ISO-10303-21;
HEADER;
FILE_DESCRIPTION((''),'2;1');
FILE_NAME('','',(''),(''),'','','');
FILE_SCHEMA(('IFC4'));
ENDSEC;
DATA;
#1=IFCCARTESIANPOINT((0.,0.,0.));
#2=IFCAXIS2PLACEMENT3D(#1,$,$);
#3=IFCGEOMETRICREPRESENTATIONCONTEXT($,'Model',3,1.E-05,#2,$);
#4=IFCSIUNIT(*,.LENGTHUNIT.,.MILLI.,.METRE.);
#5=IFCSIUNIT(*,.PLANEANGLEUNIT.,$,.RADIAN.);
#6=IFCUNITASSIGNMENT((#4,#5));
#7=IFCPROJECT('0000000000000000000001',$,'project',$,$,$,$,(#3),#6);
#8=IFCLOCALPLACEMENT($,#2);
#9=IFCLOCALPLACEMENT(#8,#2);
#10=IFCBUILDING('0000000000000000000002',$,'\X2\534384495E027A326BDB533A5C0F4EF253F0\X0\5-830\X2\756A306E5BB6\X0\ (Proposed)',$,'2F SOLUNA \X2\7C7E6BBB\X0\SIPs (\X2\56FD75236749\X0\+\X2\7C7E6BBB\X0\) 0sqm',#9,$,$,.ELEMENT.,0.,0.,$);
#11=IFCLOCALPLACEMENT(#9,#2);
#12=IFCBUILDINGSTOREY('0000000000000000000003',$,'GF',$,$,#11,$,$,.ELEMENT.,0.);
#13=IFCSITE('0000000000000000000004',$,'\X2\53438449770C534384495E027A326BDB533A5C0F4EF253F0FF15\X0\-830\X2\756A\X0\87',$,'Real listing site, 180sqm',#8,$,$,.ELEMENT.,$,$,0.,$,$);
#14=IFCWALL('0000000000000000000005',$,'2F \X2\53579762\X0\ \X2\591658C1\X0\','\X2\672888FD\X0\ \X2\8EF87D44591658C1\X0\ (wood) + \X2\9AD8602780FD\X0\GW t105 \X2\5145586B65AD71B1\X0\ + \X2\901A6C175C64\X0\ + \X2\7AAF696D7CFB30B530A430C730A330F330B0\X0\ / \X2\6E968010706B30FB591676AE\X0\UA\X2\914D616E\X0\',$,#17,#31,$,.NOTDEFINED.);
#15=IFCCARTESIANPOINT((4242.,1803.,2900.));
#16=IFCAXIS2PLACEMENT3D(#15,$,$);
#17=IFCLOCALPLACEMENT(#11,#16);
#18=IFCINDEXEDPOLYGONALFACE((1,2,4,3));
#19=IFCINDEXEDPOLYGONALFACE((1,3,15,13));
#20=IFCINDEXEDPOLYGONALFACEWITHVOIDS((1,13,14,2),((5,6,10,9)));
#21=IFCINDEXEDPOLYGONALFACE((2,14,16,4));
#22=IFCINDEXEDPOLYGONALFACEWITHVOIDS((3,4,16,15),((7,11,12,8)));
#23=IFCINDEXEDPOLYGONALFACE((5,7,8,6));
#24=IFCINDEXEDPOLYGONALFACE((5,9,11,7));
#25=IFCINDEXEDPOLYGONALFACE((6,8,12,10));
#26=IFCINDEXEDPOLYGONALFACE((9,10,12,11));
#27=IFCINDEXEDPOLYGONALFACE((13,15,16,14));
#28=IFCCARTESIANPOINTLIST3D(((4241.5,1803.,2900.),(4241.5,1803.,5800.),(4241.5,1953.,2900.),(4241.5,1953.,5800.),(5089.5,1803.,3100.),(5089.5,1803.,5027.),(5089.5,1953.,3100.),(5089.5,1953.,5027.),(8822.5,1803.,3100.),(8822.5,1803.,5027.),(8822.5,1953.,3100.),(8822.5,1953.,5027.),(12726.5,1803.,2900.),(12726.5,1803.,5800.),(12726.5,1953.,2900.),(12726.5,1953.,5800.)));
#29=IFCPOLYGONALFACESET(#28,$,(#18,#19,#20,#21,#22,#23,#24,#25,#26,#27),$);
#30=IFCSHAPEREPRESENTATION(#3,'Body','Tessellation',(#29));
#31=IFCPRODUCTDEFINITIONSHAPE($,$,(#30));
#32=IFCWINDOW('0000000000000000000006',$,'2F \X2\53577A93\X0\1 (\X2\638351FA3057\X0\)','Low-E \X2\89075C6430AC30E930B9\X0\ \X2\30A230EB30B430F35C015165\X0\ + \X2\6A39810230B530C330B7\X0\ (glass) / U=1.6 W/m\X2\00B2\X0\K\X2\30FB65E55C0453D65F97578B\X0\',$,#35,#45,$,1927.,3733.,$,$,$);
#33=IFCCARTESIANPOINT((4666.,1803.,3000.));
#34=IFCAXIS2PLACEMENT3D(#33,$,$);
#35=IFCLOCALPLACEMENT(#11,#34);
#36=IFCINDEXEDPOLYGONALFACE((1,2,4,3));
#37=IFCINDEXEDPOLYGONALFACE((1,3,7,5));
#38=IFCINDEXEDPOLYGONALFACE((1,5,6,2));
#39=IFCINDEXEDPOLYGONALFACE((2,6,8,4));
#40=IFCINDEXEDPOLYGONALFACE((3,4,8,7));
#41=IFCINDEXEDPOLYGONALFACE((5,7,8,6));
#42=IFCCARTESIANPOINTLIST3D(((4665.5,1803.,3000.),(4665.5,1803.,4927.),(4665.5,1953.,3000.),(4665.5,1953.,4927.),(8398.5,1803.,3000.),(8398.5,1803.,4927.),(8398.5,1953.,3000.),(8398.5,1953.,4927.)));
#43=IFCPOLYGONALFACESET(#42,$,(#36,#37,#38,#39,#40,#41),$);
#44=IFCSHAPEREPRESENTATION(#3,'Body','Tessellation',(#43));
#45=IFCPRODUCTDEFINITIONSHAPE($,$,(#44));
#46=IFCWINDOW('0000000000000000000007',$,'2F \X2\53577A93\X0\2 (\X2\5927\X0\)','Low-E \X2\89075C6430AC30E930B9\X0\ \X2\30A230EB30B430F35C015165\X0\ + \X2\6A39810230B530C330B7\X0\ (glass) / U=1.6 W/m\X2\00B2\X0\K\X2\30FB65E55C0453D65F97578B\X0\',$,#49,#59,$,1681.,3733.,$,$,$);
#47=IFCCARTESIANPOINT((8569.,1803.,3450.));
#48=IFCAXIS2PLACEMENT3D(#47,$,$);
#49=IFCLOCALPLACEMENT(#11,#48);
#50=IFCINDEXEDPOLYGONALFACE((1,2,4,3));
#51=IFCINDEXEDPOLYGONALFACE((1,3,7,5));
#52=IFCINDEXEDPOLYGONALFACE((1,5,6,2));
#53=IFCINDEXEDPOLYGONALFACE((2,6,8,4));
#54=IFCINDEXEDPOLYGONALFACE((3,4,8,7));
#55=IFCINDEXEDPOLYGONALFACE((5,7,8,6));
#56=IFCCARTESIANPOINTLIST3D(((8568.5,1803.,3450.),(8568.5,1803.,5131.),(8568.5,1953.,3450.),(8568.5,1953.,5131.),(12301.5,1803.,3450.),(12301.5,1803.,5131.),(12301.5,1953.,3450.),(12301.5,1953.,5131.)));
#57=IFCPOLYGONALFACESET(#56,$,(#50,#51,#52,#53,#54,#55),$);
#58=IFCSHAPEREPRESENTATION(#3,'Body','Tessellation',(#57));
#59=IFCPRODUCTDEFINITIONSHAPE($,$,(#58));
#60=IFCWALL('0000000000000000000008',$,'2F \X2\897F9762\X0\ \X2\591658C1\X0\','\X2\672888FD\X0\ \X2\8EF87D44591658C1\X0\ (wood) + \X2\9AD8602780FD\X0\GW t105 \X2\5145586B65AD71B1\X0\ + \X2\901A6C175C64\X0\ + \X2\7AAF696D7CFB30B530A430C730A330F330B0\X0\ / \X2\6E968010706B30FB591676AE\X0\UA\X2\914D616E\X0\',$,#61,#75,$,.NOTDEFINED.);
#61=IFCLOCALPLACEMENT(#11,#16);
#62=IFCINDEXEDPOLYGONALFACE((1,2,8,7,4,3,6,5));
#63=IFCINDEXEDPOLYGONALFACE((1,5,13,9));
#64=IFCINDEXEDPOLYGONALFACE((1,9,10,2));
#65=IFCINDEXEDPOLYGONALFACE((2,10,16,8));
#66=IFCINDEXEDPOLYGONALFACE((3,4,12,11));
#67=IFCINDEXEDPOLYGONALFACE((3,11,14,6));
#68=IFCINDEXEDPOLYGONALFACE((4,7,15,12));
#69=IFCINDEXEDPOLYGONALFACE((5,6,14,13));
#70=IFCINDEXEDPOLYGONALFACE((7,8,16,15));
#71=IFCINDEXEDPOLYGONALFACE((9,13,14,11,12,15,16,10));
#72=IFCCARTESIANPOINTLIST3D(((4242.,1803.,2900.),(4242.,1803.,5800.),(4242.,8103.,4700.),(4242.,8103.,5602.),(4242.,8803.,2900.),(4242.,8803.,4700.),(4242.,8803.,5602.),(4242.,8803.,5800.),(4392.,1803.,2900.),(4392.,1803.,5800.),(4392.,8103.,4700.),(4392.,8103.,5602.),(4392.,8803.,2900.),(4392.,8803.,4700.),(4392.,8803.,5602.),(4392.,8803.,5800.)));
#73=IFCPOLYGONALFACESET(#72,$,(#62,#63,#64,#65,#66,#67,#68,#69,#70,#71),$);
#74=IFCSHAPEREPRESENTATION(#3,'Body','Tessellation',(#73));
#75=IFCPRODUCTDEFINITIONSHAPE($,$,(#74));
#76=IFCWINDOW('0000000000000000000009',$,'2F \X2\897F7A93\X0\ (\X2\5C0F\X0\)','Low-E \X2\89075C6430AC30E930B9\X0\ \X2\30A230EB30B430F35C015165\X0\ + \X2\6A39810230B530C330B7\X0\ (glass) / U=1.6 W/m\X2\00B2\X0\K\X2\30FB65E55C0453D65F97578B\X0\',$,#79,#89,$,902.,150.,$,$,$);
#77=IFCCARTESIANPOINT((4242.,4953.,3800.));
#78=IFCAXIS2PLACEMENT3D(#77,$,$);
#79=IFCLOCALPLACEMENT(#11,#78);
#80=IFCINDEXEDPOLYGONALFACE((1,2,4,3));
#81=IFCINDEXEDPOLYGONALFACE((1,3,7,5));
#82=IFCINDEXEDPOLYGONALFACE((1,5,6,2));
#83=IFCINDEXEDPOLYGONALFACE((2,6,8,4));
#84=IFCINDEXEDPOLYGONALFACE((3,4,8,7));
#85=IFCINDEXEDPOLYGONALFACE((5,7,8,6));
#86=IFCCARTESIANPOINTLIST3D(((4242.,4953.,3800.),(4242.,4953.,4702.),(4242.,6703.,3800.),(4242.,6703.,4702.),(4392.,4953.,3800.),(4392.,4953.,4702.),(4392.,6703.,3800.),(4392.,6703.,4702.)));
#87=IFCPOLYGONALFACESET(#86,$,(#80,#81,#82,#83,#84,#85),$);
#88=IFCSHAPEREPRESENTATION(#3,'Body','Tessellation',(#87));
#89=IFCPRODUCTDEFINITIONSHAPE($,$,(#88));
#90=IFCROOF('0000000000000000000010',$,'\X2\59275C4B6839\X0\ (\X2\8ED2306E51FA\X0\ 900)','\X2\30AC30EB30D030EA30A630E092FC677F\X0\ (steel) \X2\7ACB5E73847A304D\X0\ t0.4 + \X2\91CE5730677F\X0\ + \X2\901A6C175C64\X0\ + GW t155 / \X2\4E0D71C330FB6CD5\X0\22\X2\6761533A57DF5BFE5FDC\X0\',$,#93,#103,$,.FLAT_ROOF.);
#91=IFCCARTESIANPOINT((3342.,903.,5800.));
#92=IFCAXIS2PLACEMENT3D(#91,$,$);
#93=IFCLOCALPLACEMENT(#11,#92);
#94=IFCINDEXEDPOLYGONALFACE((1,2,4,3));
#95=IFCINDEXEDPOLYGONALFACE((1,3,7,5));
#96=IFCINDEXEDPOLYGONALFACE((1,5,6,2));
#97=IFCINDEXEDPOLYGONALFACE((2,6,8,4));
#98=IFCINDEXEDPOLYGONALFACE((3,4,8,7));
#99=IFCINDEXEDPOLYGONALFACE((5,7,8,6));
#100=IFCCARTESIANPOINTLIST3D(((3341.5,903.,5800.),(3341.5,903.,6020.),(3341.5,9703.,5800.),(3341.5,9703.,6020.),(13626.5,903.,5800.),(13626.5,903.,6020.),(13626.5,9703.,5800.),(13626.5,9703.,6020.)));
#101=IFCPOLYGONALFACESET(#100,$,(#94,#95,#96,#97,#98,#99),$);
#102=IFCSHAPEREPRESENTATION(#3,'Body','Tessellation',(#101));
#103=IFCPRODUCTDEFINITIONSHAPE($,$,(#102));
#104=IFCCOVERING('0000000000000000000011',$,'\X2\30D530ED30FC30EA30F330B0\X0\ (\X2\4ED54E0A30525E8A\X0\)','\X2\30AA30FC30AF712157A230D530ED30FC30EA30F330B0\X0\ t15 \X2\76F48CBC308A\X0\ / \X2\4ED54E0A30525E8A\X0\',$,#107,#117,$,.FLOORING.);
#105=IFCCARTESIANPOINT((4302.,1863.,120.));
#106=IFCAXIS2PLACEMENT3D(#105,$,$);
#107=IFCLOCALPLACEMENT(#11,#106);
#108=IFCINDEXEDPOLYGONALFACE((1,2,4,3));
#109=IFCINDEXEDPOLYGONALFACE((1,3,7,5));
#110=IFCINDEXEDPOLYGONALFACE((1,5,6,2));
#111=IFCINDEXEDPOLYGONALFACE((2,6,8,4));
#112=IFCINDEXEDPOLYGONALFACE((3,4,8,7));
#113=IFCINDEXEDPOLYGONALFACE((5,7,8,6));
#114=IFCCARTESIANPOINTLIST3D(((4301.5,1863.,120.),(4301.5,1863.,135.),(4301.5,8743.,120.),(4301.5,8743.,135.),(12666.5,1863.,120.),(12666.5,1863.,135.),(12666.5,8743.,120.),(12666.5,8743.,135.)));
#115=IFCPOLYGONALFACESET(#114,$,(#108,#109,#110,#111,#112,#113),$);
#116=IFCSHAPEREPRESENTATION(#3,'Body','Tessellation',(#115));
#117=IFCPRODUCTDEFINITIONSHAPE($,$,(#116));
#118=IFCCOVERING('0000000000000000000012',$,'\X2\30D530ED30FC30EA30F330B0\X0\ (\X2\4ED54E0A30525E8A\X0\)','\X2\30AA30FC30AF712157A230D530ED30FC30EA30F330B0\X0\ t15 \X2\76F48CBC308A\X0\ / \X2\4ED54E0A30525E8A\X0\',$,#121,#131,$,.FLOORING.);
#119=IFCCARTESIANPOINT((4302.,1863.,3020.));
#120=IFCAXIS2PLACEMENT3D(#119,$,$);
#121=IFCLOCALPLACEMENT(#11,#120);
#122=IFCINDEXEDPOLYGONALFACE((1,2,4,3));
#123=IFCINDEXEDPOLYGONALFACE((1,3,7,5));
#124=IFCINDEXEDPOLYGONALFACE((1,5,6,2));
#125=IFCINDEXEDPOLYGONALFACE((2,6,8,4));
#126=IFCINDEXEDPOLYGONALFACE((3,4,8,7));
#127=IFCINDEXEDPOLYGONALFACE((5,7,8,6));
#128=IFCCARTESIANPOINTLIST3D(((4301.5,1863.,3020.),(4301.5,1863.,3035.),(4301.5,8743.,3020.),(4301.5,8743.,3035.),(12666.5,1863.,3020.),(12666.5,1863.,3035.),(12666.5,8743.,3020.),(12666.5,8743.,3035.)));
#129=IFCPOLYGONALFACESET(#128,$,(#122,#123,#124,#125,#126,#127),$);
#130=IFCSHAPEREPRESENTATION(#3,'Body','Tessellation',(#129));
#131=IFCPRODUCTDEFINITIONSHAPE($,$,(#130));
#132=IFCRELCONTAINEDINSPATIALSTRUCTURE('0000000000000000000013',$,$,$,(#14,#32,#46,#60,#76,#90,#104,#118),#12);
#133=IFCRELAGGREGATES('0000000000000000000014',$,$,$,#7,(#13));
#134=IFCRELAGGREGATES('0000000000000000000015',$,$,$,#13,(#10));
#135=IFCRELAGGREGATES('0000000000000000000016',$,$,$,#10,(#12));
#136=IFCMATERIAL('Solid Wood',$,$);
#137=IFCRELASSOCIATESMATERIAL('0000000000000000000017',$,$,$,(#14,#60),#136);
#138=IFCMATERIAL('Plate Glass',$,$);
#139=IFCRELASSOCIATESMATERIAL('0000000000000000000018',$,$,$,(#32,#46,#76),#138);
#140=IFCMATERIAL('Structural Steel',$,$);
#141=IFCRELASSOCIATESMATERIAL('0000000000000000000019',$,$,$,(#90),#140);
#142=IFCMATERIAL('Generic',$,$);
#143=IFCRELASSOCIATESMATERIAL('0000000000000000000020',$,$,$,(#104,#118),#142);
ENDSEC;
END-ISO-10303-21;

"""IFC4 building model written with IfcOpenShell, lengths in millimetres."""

from ifc_helpers import new_model, si_unit, frame, frame_2d, origin, place, context, project, spatial, rectangle, extrude, material, element, fill, save


model = new_model("IFC4")

# Units and contexts
model_context = context("Model", 3, precision=1e-05, world=origin())
ifc_project = project(units=[si_unit("LENGTHUNIT", "METRE", prefix="MILLI"), si_unit("PLANEANGLEUNIT", "RADIAN")], contexts=[model_context])

# Site, building, storey
site_placement = place(None, origin())
site = spatial("IfcSite", under=ifc_project, at=site_placement, Name="千葉県千葉市稲毛区小仲台５-830番87", ObjectType="Real listing site, 180sqm", CompositionType="ELEMENT", RefElevation=0.0)
building_placement = place(site_placement, origin())
building = spatial("IfcBuilding", under=site, at=building_placement, Name="千葉市稲毛区小仲台5-830番の家 (Proposed)", ObjectType="2F SOLUNA 籾殻SIPs (国産杉+籾殻) 0sqm", CompositionType="ELEMENT", ElevationOfRefHeight=0.0, ElevationOfTerrain=0.0)
storey_placement = place(building_placement, origin())
storey = spatial("IfcBuildingStorey", under=building, at=storey_placement, Name="GF", CompositionType="ELEMENT", Elevation=0.0)

# Shared definitions
ifc_material_1 = material(Name="Solid Wood")

# Shared definitions
ifc_material_2 = material(Name="Plate Glass")

# Wall, openings, windows
wall_1_placement = place(storey_placement, frame((4242.0, 1803.0, 2900.0)))
wall_1 = element("IfcWall", 1, at=wall_1_placement, inside=storey, material=ifc_material_1, Name="2F 南面 外壁", Description="木製 軸組外壁 (wood) + 高性能GW t105 充填断熱 + 通気層 + 窯業系サイディング / 準耐火・外皮UA配慮", PredefinedType="NOTDEFINED", context=model_context, shape_type="SweptSolid", body=[
    extrude(rectangle(XDim=8485.0, YDim=150.0, at=frame_2d((4242.0, 75.0))), frame((4242.0, 1803.0, 2900.0)), (0.0, 0.0, 1.0), 2900.0),
])
opening_1_placement = place(storey_placement, frame((4666.0, 1803.0, 3000.0)))
opening_1 = element("IfcOpeningElement", 2, at=opening_1_placement, cuts=wall_1, PredefinedType="NOTDEFINED", context=model_context, shape_type="SweptSolid", body=[
    extrude(rectangle(XDim=3733.0, YDim=150.0, at=frame_2d((1866.0, 75.0))), frame((4666.0, 1803.0, 3000.0)), (0.0, 0.0, 1.0), 1927.0),
])
opening_2_placement = place(storey_placement, frame((8569.0, 1803.0, 3450.0)))
opening_2 = element("IfcOpeningElement", 3, at=opening_2_placement, cuts=wall_1, PredefinedType="NOTDEFINED", context=model_context, shape_type="SweptSolid", body=[
    extrude(rectangle(XDim=3733.0, YDim=150.0, at=frame_2d((1866.0, 75.0))), frame((8569.0, 1803.0, 3450.0)), (0.0, 0.0, 1.0), 1681.0),
])
window_1_placement = place(storey_placement, frame((4666.0, 1803.0, 3000.0)))
window_1 = element("IfcWindow", 4, at=window_1_placement, inside=storey, material=ifc_material_2, Name="2F 南窓1 (掃出し)", Description="Low-E 複層ガラス アルゴン封入 + 樹脂サッシ (glass) / U=1.6 W/m²K・日射取得型", OverallHeight=1927.0, OverallWidth=3733.0, context=model_context, shape_type="SweptSolid", body=[
    extrude(rectangle(XDim=3733.0, YDim=150.0, at=frame_2d((1866.0, 75.0))), frame((4666.0, 1803.0, 3000.0)), (0.0, 0.0, 1.0), 1927.0),
])
fill(opening_1, window_1)
window_2_placement = place(storey_placement, frame((8569.0, 1803.0, 3450.0)))
window_2 = element("IfcWindow", 5, at=window_2_placement, inside=storey, material=ifc_material_2, Name="2F 南窓2 (大)", Description="Low-E 複層ガラス アルゴン封入 + 樹脂サッシ (glass) / U=1.6 W/m²K・日射取得型", OverallHeight=1681.0, OverallWidth=3733.0, context=model_context, shape_type="SweptSolid", body=[
    extrude(rectangle(XDim=3733.0, YDim=150.0, at=frame_2d((1866.0, 75.0))), frame((8569.0, 1803.0, 3450.0)), (0.0, 0.0, 1.0), 1681.0),
])
fill(opening_2, window_2)

# Wall, opening, window
wall_2_placement = place(storey_placement, frame((4242.0, 1803.0, 2900.0)))
wall_2 = element("IfcWall", 6, at=wall_2_placement, inside=storey, material=ifc_material_1, Name="2F 西面 外壁", Description="木製 軸組外壁 (wood) + 高性能GW t105 充填断熱 + 通気層 + 窯業系サイディング / 準耐火・外皮UA配慮", PredefinedType="NOTDEFINED", context=model_context, shape_type="SweptSolid", body=[
    extrude(rectangle(XDim=150.0, YDim=7000.0, at=frame_2d((75.0, 3500.0))), frame((4242.0, 1803.0, 2900.0)), (0.0, 0.0, 1.0), 2900.0),
])
opening_3_placement = place(storey_placement, frame((4242.0, 4953.0, 3800.0)))
opening_3 = element("IfcOpeningElement", 7, at=opening_3_placement, cuts=wall_2, PredefinedType="NOTDEFINED", context=model_context, shape_type="SweptSolid", body=[
    extrude(rectangle(XDim=150.0, YDim=1750.0, at=frame_2d((75.0, 875.0))), frame((4242.0, 4953.0, 3800.0)), (0.0, 0.0, 1.0), 902.0),
])
window_3_placement = place(storey_placement, frame((4242.0, 4953.0, 3800.0)))
window_3 = element("IfcWindow", 8, at=window_3_placement, inside=storey, material=ifc_material_2, Name="2F 西窓 (小)", Description="Low-E 複層ガラス アルゴン封入 + 樹脂サッシ (glass) / U=1.6 W/m²K・日射取得型", OverallHeight=902.0, OverallWidth=150.0, context=model_context, shape_type="SweptSolid", body=[
    extrude(rectangle(XDim=150.0, YDim=1750.0, at=frame_2d((75.0, 875.0))), frame((4242.0, 4953.0, 3800.0)), (0.0, 0.0, 1.0), 902.0),
])
fill(opening_3, window_3)

# Roof
ifc_material_3 = material(Name="Structural Steel")
roof_placement = place(storey_placement, frame((3342.0, 903.0, 5800.0)))
element("IfcRoof", 9, at=roof_placement, inside=storey, material=ifc_material_3, Name="大屋根 (軒の出 900)", Description="ガルバリウム鋼板 (steel) 立平葺き t0.4 + 野地板 + 通気層 + GW t155 / 不燃・法22条区域対応", PredefinedType="FLAT_ROOF", context=model_context, shape_type="SweptSolid", body=[
    extrude(rectangle(XDim=10285.0, YDim=8800.0, at=frame_2d((5142.0, 4400.0))), frame((3342.0, 903.0, 5800.0)), (0.0, 0.0, 1.0), 220.0),
])

# Coverings
ifc_material_4 = material(Name="Generic")
covering_1_placement = place(storey_placement, frame((4302.0, 1863.0, 120.0)))
element("IfcCovering", 10, at=covering_1_placement, inside=storey, material=ifc_material_4, Name="フローリング (仕上げ床)", Description="オーク無垢フローリング t15 直貼り / 仕上げ床", PredefinedType="FLOORING", context=model_context, shape_type="SweptSolid", body=[
    extrude(rectangle(XDim=8365.0, YDim=6880.0, at=frame_2d((4182.0, 3440.0))), frame((4302.0, 1863.0, 120.0)), (0.0, 0.0, 1.0), 15.0),
])
covering_2_placement = place(storey_placement, frame((4302.0, 1863.0, 3020.0)))
element("IfcCovering", 11, at=covering_2_placement, inside=storey, material=ifc_material_4, Name="フローリング (仕上げ床)", Description="オーク無垢フローリング t15 直貼り / 仕上げ床", PredefinedType="FLOORING", context=model_context, shape_type="SweptSolid", body=[
    extrude(rectangle(XDim=8365.0, YDim=6880.0, at=frame_2d((4182.0, 3440.0))), frame((4302.0, 1863.0, 3020.0)), (0.0, 0.0, 1.0), 15.0),
])

save(model, "model.ifc")
